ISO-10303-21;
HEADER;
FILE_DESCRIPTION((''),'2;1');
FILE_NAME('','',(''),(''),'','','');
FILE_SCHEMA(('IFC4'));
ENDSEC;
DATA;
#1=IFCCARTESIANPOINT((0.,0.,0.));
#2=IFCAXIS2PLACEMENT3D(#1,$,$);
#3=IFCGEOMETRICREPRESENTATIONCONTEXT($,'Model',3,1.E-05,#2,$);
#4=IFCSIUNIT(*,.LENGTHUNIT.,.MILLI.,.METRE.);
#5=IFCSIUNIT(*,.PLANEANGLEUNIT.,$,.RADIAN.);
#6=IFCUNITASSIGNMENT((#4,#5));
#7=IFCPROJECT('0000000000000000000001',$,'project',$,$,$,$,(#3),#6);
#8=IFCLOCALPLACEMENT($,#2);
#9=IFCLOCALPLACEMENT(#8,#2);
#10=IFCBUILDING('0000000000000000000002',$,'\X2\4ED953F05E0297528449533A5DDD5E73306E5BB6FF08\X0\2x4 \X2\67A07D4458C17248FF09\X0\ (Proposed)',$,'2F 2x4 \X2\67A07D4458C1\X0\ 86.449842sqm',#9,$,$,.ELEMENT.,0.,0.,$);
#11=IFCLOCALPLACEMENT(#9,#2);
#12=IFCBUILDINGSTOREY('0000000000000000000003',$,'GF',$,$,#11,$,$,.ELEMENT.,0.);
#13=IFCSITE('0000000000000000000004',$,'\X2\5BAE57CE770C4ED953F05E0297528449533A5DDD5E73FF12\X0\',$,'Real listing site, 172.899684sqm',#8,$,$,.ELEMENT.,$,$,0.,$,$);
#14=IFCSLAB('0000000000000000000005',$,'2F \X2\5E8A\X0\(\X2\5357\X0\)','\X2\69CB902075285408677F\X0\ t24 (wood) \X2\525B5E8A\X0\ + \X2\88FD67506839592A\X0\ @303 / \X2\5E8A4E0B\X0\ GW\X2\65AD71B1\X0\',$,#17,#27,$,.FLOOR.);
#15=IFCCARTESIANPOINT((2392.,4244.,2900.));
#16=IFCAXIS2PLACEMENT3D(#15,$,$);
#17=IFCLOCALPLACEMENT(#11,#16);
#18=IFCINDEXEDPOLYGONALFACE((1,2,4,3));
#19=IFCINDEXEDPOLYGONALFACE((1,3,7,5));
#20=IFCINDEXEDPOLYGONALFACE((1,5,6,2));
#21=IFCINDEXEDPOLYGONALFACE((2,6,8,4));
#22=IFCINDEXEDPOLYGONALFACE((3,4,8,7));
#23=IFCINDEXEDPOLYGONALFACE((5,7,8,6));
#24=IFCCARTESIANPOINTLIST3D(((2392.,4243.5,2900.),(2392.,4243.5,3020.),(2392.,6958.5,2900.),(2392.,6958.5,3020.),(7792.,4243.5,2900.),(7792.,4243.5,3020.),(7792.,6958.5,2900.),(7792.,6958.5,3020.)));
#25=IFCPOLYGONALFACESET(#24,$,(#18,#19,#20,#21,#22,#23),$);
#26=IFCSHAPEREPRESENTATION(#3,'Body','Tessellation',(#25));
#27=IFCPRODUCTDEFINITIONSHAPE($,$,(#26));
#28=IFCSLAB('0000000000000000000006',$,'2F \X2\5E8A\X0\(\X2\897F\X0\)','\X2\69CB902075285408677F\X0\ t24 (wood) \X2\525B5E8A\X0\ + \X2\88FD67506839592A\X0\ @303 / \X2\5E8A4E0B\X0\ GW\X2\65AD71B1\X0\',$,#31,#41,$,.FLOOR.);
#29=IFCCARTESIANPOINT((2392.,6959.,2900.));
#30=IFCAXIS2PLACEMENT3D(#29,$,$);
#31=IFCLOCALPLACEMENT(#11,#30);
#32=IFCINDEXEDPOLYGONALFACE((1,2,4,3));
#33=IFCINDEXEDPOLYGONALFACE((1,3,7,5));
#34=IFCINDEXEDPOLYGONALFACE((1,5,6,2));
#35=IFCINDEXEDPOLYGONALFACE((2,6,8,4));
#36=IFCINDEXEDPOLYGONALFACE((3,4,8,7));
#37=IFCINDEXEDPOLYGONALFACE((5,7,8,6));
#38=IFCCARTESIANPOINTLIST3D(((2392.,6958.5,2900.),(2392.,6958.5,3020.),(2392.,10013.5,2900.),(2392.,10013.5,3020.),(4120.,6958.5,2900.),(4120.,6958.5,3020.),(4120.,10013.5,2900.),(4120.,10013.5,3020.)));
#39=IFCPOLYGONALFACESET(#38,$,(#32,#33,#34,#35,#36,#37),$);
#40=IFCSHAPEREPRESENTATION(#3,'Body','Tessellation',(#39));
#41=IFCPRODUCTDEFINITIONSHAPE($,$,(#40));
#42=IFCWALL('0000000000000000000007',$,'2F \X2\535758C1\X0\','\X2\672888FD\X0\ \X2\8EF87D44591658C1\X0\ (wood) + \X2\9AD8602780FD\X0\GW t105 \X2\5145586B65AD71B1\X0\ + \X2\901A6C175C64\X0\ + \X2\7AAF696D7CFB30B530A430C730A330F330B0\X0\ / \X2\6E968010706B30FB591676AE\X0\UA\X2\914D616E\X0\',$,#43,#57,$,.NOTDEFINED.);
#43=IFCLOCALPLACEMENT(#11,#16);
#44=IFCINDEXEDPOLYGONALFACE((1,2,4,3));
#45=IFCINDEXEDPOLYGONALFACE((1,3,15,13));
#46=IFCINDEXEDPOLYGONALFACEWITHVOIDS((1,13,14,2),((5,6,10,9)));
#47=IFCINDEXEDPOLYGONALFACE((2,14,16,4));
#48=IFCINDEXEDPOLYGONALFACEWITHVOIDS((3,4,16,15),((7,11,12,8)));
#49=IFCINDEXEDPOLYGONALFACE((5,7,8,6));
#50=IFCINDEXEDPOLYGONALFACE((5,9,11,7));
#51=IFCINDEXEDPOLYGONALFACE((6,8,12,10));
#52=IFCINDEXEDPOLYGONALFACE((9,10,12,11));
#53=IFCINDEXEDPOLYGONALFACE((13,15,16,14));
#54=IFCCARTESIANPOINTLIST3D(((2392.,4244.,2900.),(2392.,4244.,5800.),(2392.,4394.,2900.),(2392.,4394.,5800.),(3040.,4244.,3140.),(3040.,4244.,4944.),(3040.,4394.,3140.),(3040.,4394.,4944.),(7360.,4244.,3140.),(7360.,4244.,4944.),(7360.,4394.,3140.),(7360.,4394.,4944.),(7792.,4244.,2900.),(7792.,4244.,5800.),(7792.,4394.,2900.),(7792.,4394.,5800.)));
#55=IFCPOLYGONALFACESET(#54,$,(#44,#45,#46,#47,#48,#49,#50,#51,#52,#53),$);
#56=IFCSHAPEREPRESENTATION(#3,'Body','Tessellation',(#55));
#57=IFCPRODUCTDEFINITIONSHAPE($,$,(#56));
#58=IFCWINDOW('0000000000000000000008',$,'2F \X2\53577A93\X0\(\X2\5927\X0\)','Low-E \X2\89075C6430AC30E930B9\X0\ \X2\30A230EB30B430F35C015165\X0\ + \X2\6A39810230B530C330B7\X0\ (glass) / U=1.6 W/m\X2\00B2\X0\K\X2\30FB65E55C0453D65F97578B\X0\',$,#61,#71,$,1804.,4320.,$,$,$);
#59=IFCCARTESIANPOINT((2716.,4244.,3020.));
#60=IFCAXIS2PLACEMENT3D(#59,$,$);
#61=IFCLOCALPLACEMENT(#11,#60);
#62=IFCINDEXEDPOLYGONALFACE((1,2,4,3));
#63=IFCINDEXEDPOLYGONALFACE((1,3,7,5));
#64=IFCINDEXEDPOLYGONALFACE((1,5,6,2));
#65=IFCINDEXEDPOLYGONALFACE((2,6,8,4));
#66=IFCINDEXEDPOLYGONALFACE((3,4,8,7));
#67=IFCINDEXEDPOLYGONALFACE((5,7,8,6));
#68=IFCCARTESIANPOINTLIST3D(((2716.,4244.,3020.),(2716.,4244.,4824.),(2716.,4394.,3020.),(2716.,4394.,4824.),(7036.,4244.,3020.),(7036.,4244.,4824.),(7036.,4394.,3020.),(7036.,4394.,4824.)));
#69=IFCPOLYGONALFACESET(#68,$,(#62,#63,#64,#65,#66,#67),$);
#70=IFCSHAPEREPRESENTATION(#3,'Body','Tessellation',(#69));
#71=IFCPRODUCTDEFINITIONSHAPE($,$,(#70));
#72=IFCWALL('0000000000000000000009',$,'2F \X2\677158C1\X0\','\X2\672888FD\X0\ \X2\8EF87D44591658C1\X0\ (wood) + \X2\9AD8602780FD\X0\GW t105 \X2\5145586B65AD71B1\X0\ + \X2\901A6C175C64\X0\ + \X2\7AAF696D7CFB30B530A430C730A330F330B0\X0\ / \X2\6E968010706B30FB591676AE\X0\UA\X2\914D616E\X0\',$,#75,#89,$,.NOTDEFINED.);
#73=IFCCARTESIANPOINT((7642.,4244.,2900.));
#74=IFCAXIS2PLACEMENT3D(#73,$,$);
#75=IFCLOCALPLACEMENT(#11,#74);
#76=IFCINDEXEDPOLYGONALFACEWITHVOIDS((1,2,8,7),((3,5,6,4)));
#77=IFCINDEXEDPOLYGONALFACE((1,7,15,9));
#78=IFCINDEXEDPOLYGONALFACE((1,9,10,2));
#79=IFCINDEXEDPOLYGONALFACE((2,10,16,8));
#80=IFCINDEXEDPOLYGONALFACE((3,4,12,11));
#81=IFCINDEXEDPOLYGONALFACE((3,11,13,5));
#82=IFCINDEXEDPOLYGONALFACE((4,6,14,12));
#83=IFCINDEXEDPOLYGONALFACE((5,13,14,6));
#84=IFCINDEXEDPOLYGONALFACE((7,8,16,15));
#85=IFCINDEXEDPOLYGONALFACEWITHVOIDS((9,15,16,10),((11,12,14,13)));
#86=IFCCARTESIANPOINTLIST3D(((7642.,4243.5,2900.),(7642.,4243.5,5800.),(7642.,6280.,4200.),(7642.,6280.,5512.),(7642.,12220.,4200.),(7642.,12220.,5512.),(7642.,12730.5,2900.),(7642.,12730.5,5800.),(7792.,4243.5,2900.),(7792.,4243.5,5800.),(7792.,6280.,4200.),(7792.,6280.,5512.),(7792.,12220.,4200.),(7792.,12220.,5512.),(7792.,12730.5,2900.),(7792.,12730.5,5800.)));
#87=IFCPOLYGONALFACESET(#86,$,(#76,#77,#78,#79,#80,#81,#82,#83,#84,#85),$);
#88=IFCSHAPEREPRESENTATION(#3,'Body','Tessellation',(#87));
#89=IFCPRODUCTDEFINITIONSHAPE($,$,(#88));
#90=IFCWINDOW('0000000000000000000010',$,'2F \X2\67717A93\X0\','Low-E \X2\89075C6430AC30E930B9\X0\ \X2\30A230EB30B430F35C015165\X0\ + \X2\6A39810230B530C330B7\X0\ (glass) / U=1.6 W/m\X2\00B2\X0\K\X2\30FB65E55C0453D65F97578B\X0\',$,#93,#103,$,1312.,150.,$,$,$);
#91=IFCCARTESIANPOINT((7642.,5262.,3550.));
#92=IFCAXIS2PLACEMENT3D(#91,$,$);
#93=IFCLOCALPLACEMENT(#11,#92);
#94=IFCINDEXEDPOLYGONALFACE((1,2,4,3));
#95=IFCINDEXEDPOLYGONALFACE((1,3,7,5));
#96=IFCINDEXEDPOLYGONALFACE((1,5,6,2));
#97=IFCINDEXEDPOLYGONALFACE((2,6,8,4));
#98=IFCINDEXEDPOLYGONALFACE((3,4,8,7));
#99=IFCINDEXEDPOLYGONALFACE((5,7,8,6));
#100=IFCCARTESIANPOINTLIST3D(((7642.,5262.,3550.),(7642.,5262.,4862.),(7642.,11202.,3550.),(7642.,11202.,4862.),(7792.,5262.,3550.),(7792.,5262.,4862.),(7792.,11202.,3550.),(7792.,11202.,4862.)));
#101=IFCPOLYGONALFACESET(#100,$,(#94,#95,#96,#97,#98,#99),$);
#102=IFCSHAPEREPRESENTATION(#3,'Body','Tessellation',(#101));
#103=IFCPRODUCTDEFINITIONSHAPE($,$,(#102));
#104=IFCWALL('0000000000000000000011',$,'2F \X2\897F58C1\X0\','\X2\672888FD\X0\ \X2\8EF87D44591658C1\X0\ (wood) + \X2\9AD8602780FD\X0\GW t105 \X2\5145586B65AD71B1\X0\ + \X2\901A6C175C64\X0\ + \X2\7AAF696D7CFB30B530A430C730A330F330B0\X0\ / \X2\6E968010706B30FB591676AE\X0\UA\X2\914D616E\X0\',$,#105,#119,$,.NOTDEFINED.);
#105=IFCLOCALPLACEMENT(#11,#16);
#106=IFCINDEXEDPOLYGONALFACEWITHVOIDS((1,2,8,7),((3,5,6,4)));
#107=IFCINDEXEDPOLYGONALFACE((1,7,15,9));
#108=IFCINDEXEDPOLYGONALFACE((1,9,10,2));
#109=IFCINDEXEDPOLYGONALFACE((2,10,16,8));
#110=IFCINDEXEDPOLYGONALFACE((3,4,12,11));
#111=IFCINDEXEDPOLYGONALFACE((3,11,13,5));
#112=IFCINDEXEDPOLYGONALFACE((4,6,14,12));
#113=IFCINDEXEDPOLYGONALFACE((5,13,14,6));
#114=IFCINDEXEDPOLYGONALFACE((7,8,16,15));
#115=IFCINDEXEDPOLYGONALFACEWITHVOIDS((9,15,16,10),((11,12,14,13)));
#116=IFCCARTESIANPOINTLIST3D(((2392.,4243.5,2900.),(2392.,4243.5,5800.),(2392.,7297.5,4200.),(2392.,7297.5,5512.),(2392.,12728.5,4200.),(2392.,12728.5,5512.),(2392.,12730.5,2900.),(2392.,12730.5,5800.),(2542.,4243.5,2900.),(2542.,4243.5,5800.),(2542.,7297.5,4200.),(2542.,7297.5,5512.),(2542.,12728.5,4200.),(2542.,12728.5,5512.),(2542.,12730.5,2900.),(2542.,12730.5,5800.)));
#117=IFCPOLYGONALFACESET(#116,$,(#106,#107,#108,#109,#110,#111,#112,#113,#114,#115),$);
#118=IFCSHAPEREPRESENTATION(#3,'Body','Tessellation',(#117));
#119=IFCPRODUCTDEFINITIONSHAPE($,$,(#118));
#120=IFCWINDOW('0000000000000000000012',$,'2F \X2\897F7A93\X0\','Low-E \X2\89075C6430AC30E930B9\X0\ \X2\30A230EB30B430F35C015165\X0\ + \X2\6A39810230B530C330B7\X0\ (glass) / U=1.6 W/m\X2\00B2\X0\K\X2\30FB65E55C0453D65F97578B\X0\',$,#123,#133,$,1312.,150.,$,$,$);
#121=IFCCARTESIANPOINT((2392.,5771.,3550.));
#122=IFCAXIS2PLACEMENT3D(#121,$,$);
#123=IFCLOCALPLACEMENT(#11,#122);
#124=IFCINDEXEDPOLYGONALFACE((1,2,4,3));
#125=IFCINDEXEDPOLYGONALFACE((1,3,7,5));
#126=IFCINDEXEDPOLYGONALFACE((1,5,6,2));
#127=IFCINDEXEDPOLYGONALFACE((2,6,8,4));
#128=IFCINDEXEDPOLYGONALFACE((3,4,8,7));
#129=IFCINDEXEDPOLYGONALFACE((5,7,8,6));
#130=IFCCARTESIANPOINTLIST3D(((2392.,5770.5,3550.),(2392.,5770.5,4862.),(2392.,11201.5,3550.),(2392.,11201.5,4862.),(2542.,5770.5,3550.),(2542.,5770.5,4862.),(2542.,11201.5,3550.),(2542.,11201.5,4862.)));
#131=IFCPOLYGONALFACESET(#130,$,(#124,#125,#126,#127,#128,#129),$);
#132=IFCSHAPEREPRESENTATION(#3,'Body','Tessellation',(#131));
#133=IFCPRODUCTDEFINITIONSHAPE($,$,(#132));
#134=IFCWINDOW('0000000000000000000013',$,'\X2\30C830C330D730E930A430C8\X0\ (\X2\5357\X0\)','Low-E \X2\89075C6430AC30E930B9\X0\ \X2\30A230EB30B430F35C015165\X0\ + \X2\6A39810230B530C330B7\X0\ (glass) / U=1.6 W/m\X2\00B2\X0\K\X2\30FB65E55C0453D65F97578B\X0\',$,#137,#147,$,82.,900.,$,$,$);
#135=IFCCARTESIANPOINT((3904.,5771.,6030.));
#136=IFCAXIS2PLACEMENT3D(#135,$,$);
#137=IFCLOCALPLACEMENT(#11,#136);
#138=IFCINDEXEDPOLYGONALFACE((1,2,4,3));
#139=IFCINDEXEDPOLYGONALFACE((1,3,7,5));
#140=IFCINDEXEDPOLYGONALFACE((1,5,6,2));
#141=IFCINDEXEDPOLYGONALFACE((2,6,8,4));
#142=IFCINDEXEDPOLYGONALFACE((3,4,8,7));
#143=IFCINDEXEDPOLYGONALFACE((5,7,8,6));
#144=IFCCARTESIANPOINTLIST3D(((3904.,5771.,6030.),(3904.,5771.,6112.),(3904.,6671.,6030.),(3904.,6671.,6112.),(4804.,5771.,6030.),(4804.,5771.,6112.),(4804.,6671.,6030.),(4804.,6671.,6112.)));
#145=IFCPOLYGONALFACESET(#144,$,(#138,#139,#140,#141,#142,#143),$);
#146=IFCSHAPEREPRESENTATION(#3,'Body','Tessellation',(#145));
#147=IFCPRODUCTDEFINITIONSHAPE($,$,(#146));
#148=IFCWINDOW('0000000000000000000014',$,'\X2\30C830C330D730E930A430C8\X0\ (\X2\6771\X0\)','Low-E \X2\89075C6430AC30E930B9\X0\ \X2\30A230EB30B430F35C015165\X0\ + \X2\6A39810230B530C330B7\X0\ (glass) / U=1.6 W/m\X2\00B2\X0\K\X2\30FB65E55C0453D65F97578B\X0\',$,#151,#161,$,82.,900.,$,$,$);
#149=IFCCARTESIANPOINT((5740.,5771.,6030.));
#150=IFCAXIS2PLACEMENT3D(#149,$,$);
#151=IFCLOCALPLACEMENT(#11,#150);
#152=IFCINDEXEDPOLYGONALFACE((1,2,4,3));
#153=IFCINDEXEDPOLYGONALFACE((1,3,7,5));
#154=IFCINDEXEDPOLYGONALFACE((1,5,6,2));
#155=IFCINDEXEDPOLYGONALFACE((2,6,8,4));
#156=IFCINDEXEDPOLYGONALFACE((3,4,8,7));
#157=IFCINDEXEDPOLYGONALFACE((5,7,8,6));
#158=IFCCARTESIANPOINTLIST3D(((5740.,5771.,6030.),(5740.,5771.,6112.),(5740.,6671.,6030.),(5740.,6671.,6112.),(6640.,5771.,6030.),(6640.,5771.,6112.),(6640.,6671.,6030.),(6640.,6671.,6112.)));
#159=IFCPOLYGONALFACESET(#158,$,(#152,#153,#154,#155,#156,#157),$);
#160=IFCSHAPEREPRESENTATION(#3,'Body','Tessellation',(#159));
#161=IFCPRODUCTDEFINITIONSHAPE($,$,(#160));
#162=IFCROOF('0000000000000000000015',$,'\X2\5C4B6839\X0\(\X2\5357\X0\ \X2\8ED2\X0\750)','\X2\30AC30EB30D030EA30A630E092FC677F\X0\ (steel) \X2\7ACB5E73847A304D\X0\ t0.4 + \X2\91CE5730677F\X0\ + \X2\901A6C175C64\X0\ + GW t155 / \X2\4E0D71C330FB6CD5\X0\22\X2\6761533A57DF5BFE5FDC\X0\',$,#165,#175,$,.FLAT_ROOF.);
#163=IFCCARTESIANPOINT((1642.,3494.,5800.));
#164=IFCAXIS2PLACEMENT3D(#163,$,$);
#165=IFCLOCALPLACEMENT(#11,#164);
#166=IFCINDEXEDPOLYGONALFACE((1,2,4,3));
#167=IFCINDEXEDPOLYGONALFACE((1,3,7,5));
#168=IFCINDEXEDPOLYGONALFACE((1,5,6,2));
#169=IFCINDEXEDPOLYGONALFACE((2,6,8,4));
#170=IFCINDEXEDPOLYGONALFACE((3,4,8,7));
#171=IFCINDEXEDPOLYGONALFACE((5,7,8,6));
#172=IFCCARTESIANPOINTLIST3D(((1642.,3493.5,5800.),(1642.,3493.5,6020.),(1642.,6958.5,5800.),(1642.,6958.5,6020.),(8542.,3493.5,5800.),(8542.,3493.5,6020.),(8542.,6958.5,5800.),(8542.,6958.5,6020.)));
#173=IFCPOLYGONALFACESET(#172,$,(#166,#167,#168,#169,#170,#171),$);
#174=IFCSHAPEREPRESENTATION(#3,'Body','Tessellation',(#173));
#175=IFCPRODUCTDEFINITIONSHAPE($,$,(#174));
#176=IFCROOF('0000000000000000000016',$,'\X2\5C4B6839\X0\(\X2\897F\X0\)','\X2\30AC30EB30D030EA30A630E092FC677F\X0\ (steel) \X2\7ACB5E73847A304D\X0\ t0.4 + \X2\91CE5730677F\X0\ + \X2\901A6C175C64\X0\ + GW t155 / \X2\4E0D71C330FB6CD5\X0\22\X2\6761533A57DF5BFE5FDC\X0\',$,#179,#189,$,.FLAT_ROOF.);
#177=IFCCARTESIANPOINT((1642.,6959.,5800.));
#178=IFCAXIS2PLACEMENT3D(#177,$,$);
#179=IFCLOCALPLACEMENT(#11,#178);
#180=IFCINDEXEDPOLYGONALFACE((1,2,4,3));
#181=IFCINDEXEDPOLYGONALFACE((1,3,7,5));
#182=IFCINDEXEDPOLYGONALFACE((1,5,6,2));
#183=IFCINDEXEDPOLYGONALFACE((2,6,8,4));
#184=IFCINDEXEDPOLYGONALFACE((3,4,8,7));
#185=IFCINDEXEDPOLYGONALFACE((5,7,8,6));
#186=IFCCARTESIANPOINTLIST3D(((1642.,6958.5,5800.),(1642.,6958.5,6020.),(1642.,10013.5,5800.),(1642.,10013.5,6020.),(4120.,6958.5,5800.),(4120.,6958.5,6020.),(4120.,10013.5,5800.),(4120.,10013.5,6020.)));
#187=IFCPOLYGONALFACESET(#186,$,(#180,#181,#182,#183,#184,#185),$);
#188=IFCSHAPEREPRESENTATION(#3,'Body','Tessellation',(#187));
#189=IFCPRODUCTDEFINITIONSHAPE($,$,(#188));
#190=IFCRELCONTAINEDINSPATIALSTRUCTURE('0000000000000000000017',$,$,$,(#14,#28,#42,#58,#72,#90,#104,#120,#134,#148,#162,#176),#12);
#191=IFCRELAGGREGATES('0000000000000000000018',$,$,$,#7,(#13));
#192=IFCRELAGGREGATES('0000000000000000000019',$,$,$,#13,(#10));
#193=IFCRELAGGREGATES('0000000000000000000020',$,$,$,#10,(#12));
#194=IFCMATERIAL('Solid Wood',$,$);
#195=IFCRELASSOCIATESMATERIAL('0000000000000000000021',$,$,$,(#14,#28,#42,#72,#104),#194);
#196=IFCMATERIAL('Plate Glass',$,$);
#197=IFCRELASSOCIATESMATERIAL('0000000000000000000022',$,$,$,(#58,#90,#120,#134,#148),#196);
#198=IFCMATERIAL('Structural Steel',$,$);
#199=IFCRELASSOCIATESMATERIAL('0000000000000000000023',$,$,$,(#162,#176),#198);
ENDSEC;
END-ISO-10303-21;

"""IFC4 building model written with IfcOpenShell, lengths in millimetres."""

from ifc_helpers import new_model, si_unit, frame, frame_2d, origin, place, context, project, spatial, rectangle, extrude, material, element, fill, save


model = new_model("IFC4")

# Units and contexts
model_context = context("Model", 3, precision=1e-05, world=origin())
ifc_project = project(units=[si_unit("LENGTHUNIT", "METRE", prefix="MILLI"), si_unit("PLANEANGLEUNIT", "RADIAN")], contexts=[model_context])

# Site, building, storey
site_placement = place(None, origin())
site = spatial("IfcSite", under=ifc_project, at=site_placement, Name="宮城県仙台市青葉区川平２", ObjectType="Real listing site, 172.899684sqm", CompositionType="ELEMENT", RefElevation=0.0)
building_placement = place(site_placement, origin())
building = spatial("IfcBuilding", under=site, at=building_placement, Name="仙台市青葉区川平の家（2x4 枠組壁版） (Proposed)", ObjectType="2F 2x4 枠組壁 86.449842sqm", CompositionType="ELEMENT", ElevationOfRefHeight=0.0, ElevationOfTerrain=0.0)
storey_placement = place(building_placement, origin())
storey = spatial("IfcBuildingStorey", under=building, at=storey_placement, Name="GF", CompositionType="ELEMENT", Elevation=0.0)

# Slabs
ifc_material_1 = material(Name="Solid Wood")
slab_1_placement = place(storey_placement, frame((2392.0, 4244.0, 2900.0)))
element("IfcSlab", 1, at=slab_1_placement, inside=storey, material=ifc_material_1, Name="2F 床(南)", Description="構造用合板 t24 (wood) 剛床 + 製材根太 @303 / 床下 GW断熱", PredefinedType="FLOOR", context=model_context, shape_type="SweptSolid", body=[
    extrude(rectangle(XDim=5400.0, YDim=2715.0, at=frame_2d((2700.0, 1357.0))), frame((2392.0, 4244.0, 2900.0)), (0.0, 0.0, 1.0), 120.0),
])
slab_2_placement = place(storey_placement, frame((2392.0, 6959.0, 2900.0)))
element("IfcSlab", 2, at=slab_2_placement, inside=storey, material=ifc_material_1, Name="2F 床(西)", Description="構造用合板 t24 (wood) 剛床 + 製材根太 @303 / 床下 GW断熱", PredefinedType="FLOOR", context=model_context, shape_type="SweptSolid", body=[
    extrude(rectangle(XDim=1728.0, YDim=3055.0, at=frame_2d((864.0, 1527.0))), frame((2392.0, 6959.0, 2900.0)), (0.0, 0.0, 1.0), 120.0),
])

# Walls, openings, windows
wall_1_placement = place(storey_placement, frame((2392.0, 4244.0, 2900.0)))
wall_1 = element("IfcWall", 3, at=wall_1_placement, inside=storey, material=ifc_material_1, Name="2F 南壁", Description="木製 軸組外壁 (wood) + 高性能GW t105 充填断熱 + 通気層 + 窯業系サイディング / 準耐火・外皮UA配慮", PredefinedType="NOTDEFINED", context=model_context, shape_type="SweptSolid", body=[
    extrude(rectangle(XDim=5400.0, YDim=150.0, at=frame_2d((2700.0, 75.0))), frame((2392.0, 4244.0, 2900.0)), (0.0, 0.0, 1.0), 2900.0),
])
opening_1_placement = place(storey_placement, frame((2716.0, 4244.0, 3020.0)))
opening_1 = element("IfcOpeningElement", 4, at=opening_1_placement, cuts=wall_1, PredefinedType="NOTDEFINED", context=model_context, shape_type="SweptSolid", body=[
    extrude(rectangle(XDim=4320.0, YDim=150.0, at=frame_2d((2160.0, 75.0))), frame((2716.0, 4244.0, 3020.0)), (0.0, 0.0, 1.0), 1804.0),
])
ifc_material_2 = material(Name="Plate Glass")
window_1_placement = place(storey_placement, frame((2716.0, 4244.0, 3020.0)))
window_1 = element("IfcWindow", 5, at=window_1_placement, inside=storey, material=ifc_material_2, Name="2F 南窓(大)", Description="Low-E 複層ガラス アルゴン封入 + 樹脂サッシ (glass) / U=1.6 W/m²K・日射取得型", OverallHeight=1804.0, OverallWidth=4320.0, context=model_context, shape_type="SweptSolid", body=[
    extrude(rectangle(XDim=4320.0, YDim=150.0, at=frame_2d((2160.0, 75.0))), frame((2716.0, 4244.0, 3020.0)), (0.0, 0.0, 1.0), 1804.0),
])
fill(opening_1, window_1)
wall_2_placement = place(storey_placement, frame((7642.0, 4244.0, 2900.0)))
wall_2 = element("IfcWall", 6, at=wall_2_placement, inside=storey, material=ifc_material_1, Name="2F 東壁", Description="木製 軸組外壁 (wood) + 高性能GW t105 充填断熱 + 通気層 + 窯業系サイディング / 準耐火・外皮UA配慮", PredefinedType="NOTDEFINED", context=model_context, shape_type="SweptSolid", body=[
    extrude(rectangle(XDim=150.0, YDim=8487.0, at=frame_2d((75.0, 4243.0))), frame((7642.0, 4244.0, 2900.0)), (0.0, 0.0, 1.0), 2900.0),
])
opening_2_placement = place(storey_placement, frame((7642.0, 5262.0, 3550.0)))
opening_2 = element("IfcOpeningElement", 7, at=opening_2_placement, cuts=wall_2, PredefinedType="NOTDEFINED", context=model_context, shape_type="SweptSolid", body=[
    extrude(rectangle(XDim=150.0, YDim=5940.0, at=frame_2d((75.0, 2970.0))), frame((7642.0, 5262.0, 3550.0)), (0.0, 0.0, 1.0), 1312.0),
])
window_2_placement = place(storey_placement, frame((7642.0, 5262.0, 3550.0)))
window_2 = element("IfcWindow", 8, at=window_2_placement, inside=storey, material=ifc_material_2, Name="2F 東窓", Description="Low-E 複層ガラス アルゴン封入 + 樹脂サッシ (glass) / U=1.6 W/m²K・日射取得型", OverallHeight=1312.0, OverallWidth=150.0, context=model_context, shape_type="SweptSolid", body=[
    extrude(rectangle(XDim=150.0, YDim=5940.0, at=frame_2d((75.0, 2970.0))), frame((7642.0, 5262.0, 3550.0)), (0.0, 0.0, 1.0), 1312.0),
])
fill(opening_2, window_2)
wall_3_placement = place(storey_placement, frame((2392.0, 4244.0, 2900.0)))
wall_3 = element("IfcWall", 9, at=wall_3_placement, inside=storey, material=ifc_material_1, Name="2F 西壁", Description="木製 軸組外壁 (wood) + 高性能GW t105 充填断熱 + 通気層 + 窯業系サイディング / 準耐火・外皮UA配慮", PredefinedType="NOTDEFINED", context=model_context, shape_type="SweptSolid", body=[
    extrude(rectangle(XDim=150.0, YDim=8487.0, at=frame_2d((75.0, 4243.0))), frame((2392.0, 4244.0, 2900.0)), (0.0, 0.0, 1.0), 2900.0),
])
opening_3_placement = place(storey_placement, frame((2392.0, 5771.0, 3550.0)))
opening_3 = element("IfcOpeningElement", 10, at=opening_3_placement, cuts=wall_3, PredefinedType="NOTDEFINED", context=model_context, shape_type="SweptSolid", body=[
    extrude(rectangle(XDim=150.0, YDim=5431.0, at=frame_2d((75.0, 2715.0))), frame((2392.0, 5771.0, 3550.0)), (0.0, 0.0, 1.0), 1312.0),
])
window_3_placement = place(storey_placement, frame((2392.0, 5771.0, 3550.0)))
window_3 = element("IfcWindow", 11, at=window_3_placement, inside=storey, material=ifc_material_2, Name="2F 西窓", Description="Low-E 複層ガラス アルゴン封入 + 樹脂サッシ (glass) / U=1.6 W/m²K・日射取得型", OverallHeight=1312.0, OverallWidth=150.0, context=model_context, shape_type="SweptSolid", body=[
    extrude(rectangle(XDim=150.0, YDim=5431.0, at=frame_2d((75.0, 2715.0))), frame((2392.0, 5771.0, 3550.0)), (0.0, 0.0, 1.0), 1312.0),
])
fill(opening_3, window_3)

# Windows
window_4_placement = place(storey_placement, frame((3904.0, 5771.0, 6030.0)))
element("IfcWindow", 12, at=window_4_placement, inside=storey, material=ifc_material_2, Name="トップライト (南)", Description="Low-E 複層ガラス アルゴン封入 + 樹脂サッシ (glass) / U=1.6 W/m²K・日射取得型", OverallHeight=82.0, OverallWidth=900.0, context=model_context, shape_type="SweptSolid", body=[
    extrude(rectangle(XDim=900.0, YDim=900.0, at=frame_2d((450.0, 450.0))), frame((3904.0, 5771.0, 6030.0)), (0.0, 0.0, 1.0), 82.0),
])
window_5_placement = place(storey_placement, frame((5740.0, 5771.0, 6030.0)))
element("IfcWindow", 13, at=window_5_placement, inside=storey, material=ifc_material_2, Name="トップライト (東)", Description="Low-E 複層ガラス アルゴン封入 + 樹脂サッシ (glass) / U=1.6 W/m²K・日射取得型", OverallHeight=82.0, OverallWidth=900.0, context=model_context, shape_type="SweptSolid", body=[
    extrude(rectangle(XDim=900.0, YDim=900.0, at=frame_2d((450.0, 450.0))), frame((5740.0, 5771.0, 6030.0)), (0.0, 0.0, 1.0), 82.0),
])

# Roofs
ifc_material_3 = material(Name="Structural Steel")
roof_1_placement = place(storey_placement, frame((1642.0, 3494.0, 5800.0)))
element("IfcRoof", 14, at=roof_1_placement, inside=storey, material=ifc_material_3, Name="屋根(南 軒750)", Description="ガルバリウム鋼板 (steel) 立平葺き t0.4 + 野地板 + 通気層 + GW t155 / 不燃・法22条区域対応", PredefinedType="FLAT_ROOF", context=model_context, shape_type="SweptSolid", body=[
    extrude(rectangle(XDim=6900.0, YDim=3465.0, at=frame_2d((3450.0, 1732.0))), frame((1642.0, 3494.0, 5800.0)), (0.0, 0.0, 1.0), 220.0),
])
roof_2_placement = place(storey_placement, frame((1642.0, 6959.0, 5800.0)))
element("IfcRoof", 15, at=roof_2_placement, inside=storey, material=ifc_material_3, Name="屋根(西)", Description="ガルバリウム鋼板 (steel) 立平葺き t0.4 + 野地板 + 通気層 + GW t155 / 不燃・法22条区域対応", PredefinedType="FLAT_ROOF", context=model_context, shape_type="SweptSolid", body=[
    extrude(rectangle(XDim=2478.0, YDim=3055.0, at=frame_2d((1239.0, 1527.0))), frame((1642.0, 6959.0, 5800.0)), (0.0, 0.0, 1.0), 220.0),
])

save(model, "model.ifc")
